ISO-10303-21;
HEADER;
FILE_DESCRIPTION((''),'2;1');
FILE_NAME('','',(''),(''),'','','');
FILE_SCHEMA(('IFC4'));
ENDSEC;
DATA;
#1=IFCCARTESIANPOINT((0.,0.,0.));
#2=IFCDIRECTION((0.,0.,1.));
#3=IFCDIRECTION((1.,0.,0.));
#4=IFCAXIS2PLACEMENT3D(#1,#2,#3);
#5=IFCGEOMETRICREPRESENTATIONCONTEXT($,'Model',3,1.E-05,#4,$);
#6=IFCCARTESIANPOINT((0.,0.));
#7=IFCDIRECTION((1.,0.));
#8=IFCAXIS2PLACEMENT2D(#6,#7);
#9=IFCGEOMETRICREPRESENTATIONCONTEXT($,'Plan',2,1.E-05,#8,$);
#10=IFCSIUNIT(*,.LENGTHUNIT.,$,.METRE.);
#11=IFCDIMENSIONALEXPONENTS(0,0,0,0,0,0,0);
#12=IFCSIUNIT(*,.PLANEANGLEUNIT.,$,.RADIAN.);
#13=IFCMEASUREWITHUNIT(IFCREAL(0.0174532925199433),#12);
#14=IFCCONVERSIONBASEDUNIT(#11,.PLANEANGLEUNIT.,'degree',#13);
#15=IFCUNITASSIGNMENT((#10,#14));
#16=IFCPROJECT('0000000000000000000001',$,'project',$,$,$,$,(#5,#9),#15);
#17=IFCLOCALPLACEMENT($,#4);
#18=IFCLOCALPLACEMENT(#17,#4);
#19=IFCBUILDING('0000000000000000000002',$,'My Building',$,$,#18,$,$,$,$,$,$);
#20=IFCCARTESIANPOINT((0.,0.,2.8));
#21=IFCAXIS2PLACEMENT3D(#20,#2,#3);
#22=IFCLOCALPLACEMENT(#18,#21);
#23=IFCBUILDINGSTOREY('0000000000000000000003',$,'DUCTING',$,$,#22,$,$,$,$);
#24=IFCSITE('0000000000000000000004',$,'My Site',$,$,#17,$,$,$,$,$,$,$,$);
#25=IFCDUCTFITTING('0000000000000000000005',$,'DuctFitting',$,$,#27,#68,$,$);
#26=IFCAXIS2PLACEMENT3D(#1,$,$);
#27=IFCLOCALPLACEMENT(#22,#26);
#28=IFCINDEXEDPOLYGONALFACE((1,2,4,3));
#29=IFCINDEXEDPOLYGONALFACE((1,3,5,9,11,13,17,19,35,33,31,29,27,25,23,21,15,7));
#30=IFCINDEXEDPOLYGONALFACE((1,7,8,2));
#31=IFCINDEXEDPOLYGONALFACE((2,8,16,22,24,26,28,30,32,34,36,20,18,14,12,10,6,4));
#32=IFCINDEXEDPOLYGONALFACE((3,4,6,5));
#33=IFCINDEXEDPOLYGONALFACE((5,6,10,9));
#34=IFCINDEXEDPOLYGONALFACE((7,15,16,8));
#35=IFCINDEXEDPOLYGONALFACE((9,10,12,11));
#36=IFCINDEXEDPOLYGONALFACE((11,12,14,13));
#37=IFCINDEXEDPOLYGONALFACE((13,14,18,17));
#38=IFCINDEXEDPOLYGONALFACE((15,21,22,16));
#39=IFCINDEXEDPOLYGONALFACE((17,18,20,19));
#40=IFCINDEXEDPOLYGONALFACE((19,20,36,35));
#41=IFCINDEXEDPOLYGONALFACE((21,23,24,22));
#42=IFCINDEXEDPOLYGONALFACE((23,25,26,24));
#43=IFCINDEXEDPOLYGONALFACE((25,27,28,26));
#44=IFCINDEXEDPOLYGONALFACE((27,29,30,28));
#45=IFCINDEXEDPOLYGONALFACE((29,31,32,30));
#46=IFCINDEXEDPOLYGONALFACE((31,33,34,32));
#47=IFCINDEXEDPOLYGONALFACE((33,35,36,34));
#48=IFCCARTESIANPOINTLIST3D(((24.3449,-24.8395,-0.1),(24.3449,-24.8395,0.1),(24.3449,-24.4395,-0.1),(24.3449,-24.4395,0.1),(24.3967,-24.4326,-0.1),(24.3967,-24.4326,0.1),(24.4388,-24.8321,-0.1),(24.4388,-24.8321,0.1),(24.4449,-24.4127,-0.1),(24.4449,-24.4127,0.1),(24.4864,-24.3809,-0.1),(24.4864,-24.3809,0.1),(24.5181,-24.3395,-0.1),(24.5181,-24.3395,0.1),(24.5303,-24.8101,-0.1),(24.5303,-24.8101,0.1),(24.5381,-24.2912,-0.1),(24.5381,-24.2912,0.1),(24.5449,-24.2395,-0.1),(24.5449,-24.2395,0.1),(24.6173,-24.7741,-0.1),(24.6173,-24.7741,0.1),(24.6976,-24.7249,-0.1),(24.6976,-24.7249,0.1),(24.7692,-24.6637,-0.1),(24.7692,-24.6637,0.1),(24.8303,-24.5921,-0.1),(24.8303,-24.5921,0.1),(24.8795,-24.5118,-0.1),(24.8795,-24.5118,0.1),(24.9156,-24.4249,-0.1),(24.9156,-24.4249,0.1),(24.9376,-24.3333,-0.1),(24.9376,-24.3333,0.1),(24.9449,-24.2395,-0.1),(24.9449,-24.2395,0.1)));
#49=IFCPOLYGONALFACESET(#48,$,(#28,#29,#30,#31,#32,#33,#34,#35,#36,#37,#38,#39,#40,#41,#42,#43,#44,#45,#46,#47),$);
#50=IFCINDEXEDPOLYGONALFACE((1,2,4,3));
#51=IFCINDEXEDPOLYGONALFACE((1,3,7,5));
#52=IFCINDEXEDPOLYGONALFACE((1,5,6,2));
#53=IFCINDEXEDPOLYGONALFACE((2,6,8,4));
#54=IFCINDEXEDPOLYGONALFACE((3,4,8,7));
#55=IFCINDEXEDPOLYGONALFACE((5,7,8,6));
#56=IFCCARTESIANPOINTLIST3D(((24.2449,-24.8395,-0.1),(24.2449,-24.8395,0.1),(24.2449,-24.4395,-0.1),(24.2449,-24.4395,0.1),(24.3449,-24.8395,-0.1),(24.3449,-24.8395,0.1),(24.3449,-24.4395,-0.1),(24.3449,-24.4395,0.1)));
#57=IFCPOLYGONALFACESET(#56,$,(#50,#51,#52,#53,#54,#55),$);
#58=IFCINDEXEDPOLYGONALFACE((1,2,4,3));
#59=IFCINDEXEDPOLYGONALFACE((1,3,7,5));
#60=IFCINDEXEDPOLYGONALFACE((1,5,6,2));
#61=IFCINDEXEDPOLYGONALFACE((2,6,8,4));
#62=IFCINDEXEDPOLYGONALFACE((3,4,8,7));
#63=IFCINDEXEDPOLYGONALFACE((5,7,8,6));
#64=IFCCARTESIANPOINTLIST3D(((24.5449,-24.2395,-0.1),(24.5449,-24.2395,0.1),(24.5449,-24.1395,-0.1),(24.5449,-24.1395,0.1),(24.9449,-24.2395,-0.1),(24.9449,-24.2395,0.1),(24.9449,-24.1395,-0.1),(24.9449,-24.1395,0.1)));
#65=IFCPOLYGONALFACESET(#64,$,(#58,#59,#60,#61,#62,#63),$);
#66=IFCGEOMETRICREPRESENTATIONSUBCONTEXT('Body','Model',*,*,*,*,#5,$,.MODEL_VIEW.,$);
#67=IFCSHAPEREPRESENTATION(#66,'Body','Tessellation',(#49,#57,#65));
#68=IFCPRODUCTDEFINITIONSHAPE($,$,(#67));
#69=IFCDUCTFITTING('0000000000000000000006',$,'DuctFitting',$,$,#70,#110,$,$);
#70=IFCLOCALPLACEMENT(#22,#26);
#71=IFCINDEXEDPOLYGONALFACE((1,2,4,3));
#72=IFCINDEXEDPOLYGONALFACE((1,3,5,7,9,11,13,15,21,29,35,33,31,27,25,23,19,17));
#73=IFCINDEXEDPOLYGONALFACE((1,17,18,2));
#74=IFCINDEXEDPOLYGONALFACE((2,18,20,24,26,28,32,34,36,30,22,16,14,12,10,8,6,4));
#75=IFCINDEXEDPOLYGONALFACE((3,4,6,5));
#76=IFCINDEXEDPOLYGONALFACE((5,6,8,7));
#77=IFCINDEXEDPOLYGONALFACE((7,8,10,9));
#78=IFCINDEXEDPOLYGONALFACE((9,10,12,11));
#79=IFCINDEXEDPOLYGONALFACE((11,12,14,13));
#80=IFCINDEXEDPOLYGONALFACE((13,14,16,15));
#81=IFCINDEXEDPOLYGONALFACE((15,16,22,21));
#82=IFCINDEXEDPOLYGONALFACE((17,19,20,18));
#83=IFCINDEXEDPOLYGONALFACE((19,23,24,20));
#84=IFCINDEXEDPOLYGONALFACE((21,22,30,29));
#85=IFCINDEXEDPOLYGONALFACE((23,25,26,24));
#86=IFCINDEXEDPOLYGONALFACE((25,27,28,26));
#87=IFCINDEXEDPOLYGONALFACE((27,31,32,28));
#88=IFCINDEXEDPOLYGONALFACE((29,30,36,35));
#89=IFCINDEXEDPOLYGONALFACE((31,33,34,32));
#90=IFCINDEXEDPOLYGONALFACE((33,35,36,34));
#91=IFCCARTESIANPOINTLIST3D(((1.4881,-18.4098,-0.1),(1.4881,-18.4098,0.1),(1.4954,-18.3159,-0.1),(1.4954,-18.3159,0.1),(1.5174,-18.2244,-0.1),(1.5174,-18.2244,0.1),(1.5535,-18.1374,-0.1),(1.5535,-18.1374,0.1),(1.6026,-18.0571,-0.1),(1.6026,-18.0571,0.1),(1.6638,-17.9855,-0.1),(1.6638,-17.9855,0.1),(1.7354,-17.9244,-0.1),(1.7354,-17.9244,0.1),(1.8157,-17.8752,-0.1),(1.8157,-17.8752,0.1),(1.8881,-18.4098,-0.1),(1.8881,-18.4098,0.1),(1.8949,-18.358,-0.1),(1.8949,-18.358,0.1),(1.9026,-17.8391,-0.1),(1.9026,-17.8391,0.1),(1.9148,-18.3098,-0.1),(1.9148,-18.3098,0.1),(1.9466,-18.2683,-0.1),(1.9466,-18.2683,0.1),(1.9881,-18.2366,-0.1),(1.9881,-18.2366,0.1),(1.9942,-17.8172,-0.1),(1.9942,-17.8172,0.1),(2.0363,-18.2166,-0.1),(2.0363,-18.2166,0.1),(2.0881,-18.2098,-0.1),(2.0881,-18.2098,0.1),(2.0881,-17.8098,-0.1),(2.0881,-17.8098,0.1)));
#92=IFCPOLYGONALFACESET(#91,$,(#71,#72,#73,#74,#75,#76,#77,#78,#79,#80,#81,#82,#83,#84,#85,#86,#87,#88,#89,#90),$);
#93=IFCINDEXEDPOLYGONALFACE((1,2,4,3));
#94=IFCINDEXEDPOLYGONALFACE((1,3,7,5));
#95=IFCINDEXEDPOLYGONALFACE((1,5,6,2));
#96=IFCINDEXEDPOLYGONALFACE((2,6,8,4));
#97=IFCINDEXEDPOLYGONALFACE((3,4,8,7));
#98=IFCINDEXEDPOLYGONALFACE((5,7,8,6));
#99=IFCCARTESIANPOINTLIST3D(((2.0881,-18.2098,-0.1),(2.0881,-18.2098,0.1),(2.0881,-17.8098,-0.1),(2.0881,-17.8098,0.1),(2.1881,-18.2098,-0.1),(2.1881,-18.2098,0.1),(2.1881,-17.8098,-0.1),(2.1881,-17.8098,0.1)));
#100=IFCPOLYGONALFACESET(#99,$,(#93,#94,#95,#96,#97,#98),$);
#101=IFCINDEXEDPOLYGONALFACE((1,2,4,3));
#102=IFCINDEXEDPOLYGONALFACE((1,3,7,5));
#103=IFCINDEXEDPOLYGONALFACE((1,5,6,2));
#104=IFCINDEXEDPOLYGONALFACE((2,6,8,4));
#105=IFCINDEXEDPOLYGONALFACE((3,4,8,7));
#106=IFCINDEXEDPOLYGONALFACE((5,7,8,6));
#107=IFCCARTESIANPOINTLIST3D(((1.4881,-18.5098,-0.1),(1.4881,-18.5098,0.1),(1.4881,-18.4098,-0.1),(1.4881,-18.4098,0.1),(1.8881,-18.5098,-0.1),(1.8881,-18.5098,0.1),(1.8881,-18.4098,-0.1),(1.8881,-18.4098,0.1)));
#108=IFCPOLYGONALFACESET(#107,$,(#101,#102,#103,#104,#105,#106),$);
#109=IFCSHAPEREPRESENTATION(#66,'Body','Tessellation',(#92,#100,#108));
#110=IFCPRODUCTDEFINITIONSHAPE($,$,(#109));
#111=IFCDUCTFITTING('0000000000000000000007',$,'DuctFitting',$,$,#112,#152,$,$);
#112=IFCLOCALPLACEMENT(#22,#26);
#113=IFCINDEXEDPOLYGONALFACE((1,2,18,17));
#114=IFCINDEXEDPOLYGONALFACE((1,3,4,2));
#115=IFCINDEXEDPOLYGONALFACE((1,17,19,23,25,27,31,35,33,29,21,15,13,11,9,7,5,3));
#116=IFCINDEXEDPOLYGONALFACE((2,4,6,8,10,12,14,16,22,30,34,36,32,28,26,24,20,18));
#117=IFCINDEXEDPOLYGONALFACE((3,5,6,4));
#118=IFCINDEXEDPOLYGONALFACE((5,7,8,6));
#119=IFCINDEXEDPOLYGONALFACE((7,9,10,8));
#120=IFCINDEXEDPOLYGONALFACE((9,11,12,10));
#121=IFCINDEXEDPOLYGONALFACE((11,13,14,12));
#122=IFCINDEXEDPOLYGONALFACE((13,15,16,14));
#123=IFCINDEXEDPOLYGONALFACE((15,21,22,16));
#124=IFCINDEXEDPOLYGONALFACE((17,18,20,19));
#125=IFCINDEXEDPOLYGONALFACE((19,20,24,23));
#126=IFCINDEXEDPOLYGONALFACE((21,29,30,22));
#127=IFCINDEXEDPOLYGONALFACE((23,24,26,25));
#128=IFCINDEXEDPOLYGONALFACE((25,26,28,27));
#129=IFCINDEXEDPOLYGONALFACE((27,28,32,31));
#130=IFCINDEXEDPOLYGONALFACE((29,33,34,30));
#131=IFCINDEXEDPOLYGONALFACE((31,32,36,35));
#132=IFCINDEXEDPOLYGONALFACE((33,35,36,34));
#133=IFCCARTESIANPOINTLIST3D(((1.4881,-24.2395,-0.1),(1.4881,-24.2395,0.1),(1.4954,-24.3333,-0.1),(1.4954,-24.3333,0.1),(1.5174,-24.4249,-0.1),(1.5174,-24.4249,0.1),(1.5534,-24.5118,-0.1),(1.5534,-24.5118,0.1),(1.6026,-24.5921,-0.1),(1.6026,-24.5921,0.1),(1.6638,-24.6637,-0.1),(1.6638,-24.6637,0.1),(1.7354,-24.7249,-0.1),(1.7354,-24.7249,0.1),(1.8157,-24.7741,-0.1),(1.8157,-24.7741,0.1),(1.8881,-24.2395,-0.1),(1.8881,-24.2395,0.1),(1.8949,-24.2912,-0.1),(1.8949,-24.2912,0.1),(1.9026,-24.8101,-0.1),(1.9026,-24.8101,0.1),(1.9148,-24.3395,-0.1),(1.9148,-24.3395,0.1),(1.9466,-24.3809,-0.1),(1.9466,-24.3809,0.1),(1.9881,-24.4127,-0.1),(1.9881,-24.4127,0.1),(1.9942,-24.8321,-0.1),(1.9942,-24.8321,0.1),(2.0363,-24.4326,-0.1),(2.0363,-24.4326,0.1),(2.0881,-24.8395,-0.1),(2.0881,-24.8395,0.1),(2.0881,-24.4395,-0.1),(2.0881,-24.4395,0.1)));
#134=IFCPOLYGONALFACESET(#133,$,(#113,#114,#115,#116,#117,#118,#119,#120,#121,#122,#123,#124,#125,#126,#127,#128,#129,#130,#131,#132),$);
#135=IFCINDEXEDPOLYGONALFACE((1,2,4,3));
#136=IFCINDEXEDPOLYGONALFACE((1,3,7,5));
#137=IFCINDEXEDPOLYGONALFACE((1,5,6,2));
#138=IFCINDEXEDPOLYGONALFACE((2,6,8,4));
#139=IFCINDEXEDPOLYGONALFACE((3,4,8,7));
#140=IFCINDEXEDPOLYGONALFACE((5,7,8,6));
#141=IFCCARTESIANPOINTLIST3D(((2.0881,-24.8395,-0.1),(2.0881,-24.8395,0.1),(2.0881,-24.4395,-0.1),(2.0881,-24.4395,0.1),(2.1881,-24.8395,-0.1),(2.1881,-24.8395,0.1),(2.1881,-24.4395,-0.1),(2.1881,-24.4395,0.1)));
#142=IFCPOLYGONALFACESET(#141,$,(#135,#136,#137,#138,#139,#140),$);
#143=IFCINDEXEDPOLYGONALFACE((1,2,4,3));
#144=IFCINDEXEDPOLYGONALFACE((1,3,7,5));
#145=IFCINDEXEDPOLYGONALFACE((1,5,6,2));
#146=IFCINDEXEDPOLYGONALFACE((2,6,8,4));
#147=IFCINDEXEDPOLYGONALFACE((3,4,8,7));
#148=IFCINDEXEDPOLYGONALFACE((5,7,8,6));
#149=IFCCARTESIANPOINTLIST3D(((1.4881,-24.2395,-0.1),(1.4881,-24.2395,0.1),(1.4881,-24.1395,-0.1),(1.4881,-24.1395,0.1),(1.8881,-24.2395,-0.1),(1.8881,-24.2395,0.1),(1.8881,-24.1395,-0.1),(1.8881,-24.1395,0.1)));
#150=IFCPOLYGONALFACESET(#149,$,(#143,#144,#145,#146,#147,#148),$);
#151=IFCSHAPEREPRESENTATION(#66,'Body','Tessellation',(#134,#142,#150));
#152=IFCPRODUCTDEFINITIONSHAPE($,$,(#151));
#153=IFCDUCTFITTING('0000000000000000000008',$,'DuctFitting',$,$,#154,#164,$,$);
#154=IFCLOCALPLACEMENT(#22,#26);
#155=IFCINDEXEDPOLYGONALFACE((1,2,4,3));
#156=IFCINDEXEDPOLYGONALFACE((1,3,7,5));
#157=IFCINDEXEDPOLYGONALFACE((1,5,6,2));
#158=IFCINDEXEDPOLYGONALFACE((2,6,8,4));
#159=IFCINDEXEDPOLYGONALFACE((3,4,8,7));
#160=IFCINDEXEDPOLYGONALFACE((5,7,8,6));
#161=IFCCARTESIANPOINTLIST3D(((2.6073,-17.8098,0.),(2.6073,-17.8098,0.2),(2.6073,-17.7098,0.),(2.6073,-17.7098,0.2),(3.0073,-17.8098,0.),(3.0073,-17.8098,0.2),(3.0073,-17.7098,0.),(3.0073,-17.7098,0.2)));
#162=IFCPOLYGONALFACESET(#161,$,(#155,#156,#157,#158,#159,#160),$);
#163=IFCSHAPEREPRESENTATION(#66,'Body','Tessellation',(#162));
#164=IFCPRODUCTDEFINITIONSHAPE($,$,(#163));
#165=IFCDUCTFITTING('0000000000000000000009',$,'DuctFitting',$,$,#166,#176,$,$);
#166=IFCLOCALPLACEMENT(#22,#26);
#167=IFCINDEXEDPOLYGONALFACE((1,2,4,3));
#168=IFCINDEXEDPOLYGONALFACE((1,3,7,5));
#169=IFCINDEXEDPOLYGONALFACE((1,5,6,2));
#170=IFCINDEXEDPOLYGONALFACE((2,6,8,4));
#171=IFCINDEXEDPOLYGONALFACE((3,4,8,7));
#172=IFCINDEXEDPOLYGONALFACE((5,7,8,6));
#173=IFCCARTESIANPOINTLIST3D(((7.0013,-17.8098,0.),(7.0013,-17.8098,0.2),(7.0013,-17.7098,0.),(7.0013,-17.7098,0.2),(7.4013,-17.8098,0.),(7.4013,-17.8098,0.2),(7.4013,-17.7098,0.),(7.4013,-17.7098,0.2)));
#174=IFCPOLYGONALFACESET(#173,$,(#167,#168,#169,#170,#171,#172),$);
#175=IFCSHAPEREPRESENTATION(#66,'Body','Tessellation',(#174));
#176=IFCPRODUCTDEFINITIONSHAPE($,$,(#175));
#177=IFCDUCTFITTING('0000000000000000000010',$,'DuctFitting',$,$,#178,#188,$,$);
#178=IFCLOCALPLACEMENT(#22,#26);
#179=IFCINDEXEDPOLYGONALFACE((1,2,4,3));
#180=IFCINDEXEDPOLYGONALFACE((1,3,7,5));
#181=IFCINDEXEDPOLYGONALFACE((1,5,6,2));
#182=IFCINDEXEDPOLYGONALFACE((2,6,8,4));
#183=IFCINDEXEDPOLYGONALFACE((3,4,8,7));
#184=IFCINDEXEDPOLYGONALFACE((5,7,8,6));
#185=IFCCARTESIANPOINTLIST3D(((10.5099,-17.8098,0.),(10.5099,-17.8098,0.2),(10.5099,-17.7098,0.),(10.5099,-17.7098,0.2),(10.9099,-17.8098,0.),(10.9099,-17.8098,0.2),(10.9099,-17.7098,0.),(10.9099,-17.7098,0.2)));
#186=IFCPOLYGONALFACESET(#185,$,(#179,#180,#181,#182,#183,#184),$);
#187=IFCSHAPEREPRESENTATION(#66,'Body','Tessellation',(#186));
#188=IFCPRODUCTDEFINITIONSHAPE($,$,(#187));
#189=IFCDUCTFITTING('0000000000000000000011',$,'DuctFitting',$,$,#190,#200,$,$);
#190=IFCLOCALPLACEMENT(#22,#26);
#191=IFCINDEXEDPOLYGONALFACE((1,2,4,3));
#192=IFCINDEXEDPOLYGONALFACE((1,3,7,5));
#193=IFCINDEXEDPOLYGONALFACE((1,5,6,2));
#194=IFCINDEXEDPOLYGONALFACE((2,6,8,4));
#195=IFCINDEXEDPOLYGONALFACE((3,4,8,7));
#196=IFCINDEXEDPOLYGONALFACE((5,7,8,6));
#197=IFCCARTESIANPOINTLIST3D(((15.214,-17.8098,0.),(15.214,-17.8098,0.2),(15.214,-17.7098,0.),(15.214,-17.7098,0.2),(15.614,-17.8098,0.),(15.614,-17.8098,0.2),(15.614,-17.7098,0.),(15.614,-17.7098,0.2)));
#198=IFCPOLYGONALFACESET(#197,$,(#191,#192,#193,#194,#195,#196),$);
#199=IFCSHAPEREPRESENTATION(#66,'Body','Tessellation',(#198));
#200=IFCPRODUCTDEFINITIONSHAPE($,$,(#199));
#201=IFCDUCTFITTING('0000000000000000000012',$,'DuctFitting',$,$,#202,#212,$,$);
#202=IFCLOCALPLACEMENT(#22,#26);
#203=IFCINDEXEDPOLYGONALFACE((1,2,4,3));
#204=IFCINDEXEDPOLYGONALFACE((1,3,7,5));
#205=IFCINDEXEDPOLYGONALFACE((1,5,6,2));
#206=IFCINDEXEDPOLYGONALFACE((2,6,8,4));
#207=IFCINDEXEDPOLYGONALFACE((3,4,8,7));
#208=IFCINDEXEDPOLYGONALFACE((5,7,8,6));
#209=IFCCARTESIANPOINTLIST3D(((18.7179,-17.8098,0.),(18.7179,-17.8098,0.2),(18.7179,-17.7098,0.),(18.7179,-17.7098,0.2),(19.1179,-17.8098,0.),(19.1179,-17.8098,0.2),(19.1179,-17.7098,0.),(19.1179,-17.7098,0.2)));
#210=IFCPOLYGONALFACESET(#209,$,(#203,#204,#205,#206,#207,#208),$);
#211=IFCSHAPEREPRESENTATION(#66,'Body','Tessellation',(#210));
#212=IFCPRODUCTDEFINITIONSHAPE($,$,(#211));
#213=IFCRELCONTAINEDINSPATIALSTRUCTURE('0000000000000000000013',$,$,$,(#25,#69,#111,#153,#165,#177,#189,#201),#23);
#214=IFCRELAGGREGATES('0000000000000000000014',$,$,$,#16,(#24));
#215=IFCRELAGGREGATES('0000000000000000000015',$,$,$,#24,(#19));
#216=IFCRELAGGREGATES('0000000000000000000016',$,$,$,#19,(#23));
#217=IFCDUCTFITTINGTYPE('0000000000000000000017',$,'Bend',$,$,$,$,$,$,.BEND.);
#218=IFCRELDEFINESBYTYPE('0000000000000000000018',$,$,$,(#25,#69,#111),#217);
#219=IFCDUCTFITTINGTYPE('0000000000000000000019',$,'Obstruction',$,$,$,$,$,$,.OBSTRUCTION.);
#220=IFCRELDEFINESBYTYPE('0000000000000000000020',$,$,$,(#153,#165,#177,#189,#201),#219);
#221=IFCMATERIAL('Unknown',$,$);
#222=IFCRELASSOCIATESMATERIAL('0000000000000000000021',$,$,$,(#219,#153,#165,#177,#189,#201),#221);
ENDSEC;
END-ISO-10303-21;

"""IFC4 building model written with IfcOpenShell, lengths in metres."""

from ifc_helpers import new_model, entity, si_unit, converted_unit, frame, origin_with_axes, origin_2d_with_axis, place, context, subcontext, project, spatial, line, arc, indexed_curve, rectangle, outline, extrude, source, transform, mapped, material, material_profile, profile_set, profile_usage, type_object, type_shapes, element, save


model = new_model("IFC4")

# Units and contexts
model_context = context("Model", 3, precision=1e-05, world=origin_with_axes())
plan_context = context("Plan", 2, precision=1e-05, world=origin_2d_with_axis())
body_context = subcontext(model_context, "Body", "Model", "MODEL_VIEW")
ifc_project = project(units=[si_unit("LENGTHUNIT", "METRE"), converted_unit("PLANEANGLEUNIT", "degree", entity("IfcReal", 0.0174532925199433), si_unit("PLANEANGLEUNIT", "RADIAN"), dimensions=[0, 0, 0, 0, 0, 0, 0])], contexts=[model_context, plan_context])

# Site, building, storey
site_placement = place(None, origin_with_axes())
site = spatial("IfcSite", under=ifc_project, at=site_placement, Name="My Site")
building_placement = place(site_placement, origin_with_axes())
building = spatial("IfcBuilding", under=site, at=building_placement, Name="My Building")
storey_placement = place(building_placement, frame((0.0, 0.0, 2.8), z_axis=(0.0, 0.0, 1.0), x_axis=(1.0, 0.0, 0.0)))
storey = spatial("IfcBuildingStorey", under=building, at=storey_placement, Name="DUCTING")

# Shared definitions
ifc_material = material(Name="Unknown")

# Duct fittings
duct_fitting_type_1 = type_object("IfcDuctFittingType", Name="Bend", PredefinedType="BEND")
shared_shape = source(origin_with_axes(), body_context, "Body", "SweptSolid", [
    extrude(outline(indexed_curve([(-0.2, 0.0), (-0.2586, -0.1414), (-0.4, -0.2), (-0.4, -0.6), (0.0243, -0.4243), (0.2, 0.0)], segments=[arc(1, 2, 3), line(3, 4), arc(4, 5, 6), line(6, 1)])), frame((0.0, -0.1, -0.1), z_axis=(0.0, -1.0, 0.0), x_axis=(1.0, 0.0, 0.0)), (0.0, 0.0, -1.0), 0.2),
    extrude(rectangle(XDim=0.4, YDim=0.2), origin_with_axes(), (0.0, 0.0, -1.0), 0.1),
    extrude(rectangle(XDim=0.4, YDim=0.2), frame((-0.4, 0.0, -0.5), z_axis=(-1.0, 0.0, 0.0), x_axis=(0.0, 0.0, -1.0)), (0.0, 0.0, 1.0), 0.1),
])
type_shapes(duct_fitting_type_1, [shared_shape])
for number, where, z_axis, x_axis, name in (
    (1, (24.2449, -24.6395, 0.0), (-1.0, 0.0, 0.0), (0.0, -1.0, 0.0), "DuctFitting"),
    (2, (2.1881, -18.0098, 0.0), (1.0, 0.0, 0.0), (0.0, 1.0, 0.0), "DuctFitting"),
    (3, (2.1881, -24.6395, 0.0), (1.0, 0.0, 0.0), (0.0, -1.0, 0.0), "DuctFitting"),
):
    element("IfcDuctFitting", number, at=place(storey_placement, frame(where, z_axis=z_axis, x_axis=x_axis)), inside=storey, type_object=duct_fitting_type_1, Name=name, context=body_context, shape_type="MappedRepresentation", body=[
        mapped(shared_shape, transform((0.0, 0.0, 0.0), x_axis=(1.0, 0.0, 0.0), y_axis=(0.0, 1.0, 0.0), z_axis=(0.0, 0.0, 1.0), scale=1.0)),
    ])
ifc_material_profile_1 = material_profile(ifc_material, rectangle(XDim=0.4, YDim=0.2))
ifc_profile_set_1 = profile_set([ifc_material_profile_1])
ifc_profile_usage_1 = profile_usage(ifc_profile_set_1, cardinal=5)
duct_fitting_type_2 = type_object("IfcDuctFittingType", Name="Obstruction", PredefinedType="OBSTRUCTION", material=ifc_profile_set_1)
duct_fitting_1_placement = place(storey_placement, frame((2.8073, -17.8098, 0.1), z_axis=(0.0, 1.0, 0.0), x_axis=(-1.0, 0.0, 0.0)))
element("IfcDuctFitting", 4, at=duct_fitting_1_placement, inside=storey, type_object=duct_fitting_type_2, material=ifc_profile_usage_1, Name="DuctFitting", context=body_context, shape_type="SweptSolid", body=[
    extrude(rectangle(XDim=0.4, YDim=0.2), origin_with_axes(), (0.0, 0.0, 1.0), 0.1),
])
ifc_profile_usage_2 = profile_usage(ifc_profile_set_1, cardinal=5)
duct_fitting_2_placement = place(storey_placement, frame((7.2013, -17.8098, 0.1), z_axis=(0.0, 1.0, 0.0), x_axis=(-1.0, 0.0, 0.0)))
element("IfcDuctFitting", 5, at=duct_fitting_2_placement, inside=storey, type_object=duct_fitting_type_2, material=ifc_profile_usage_2, Name="DuctFitting", context=body_context, shape_type="SweptSolid", body=[
    extrude(rectangle(XDim=0.4, YDim=0.2), origin_with_axes(), (0.0, 0.0, 1.0), 0.1),
])
ifc_profile_usage_3 = profile_usage(ifc_profile_set_1, cardinal=5)
duct_fitting_3_placement = place(storey_placement, frame((10.7099, -17.8098, 0.1), z_axis=(0.0, 1.0, 0.0), x_axis=(-1.0, 0.0, 0.0)))
element("IfcDuctFitting", 6, at=duct_fitting_3_placement, inside=storey, type_object=duct_fitting_type_2, material=ifc_profile_usage_3, Name="DuctFitting", context=body_context, shape_type="SweptSolid", body=[
    extrude(rectangle(XDim=0.4, YDim=0.2), origin_with_axes(), (0.0, 0.0, 1.0), 0.1),
])
ifc_profile_usage_4 = profile_usage(ifc_profile_set_1, cardinal=5)
duct_fitting_4_placement = place(storey_placement, frame((15.414, -17.8098, 0.1), z_axis=(0.0, 1.0, 0.0), x_axis=(-1.0, 0.0, 0.0)))
element("IfcDuctFitting", 7, at=duct_fitting_4_placement, inside=storey, type_object=duct_fitting_type_2, material=ifc_profile_usage_4, Name="DuctFitting", context=body_context, shape_type="SweptSolid", body=[
    extrude(rectangle(XDim=0.4, YDim=0.2), origin_with_axes(), (0.0, 0.0, 1.0), 0.1),
])
ifc_profile_usage_5 = profile_usage(ifc_profile_set_1, cardinal=5)
duct_fitting_5_placement = place(storey_placement, frame((18.9179, -17.8098, 0.1), z_axis=(0.0, 1.0, 0.0), x_axis=(-1.0, 0.0, 0.0)))
element("IfcDuctFitting", 8, at=duct_fitting_5_placement, inside=storey, type_object=duct_fitting_type_2, material=ifc_profile_usage_5, Name="DuctFitting", context=body_context, shape_type="SweptSolid", body=[
    extrude(rectangle(XDim=0.4, YDim=0.2), origin_with_axes(), (0.0, 0.0, 1.0), 0.1),
])

save(model, "model.ifc")
